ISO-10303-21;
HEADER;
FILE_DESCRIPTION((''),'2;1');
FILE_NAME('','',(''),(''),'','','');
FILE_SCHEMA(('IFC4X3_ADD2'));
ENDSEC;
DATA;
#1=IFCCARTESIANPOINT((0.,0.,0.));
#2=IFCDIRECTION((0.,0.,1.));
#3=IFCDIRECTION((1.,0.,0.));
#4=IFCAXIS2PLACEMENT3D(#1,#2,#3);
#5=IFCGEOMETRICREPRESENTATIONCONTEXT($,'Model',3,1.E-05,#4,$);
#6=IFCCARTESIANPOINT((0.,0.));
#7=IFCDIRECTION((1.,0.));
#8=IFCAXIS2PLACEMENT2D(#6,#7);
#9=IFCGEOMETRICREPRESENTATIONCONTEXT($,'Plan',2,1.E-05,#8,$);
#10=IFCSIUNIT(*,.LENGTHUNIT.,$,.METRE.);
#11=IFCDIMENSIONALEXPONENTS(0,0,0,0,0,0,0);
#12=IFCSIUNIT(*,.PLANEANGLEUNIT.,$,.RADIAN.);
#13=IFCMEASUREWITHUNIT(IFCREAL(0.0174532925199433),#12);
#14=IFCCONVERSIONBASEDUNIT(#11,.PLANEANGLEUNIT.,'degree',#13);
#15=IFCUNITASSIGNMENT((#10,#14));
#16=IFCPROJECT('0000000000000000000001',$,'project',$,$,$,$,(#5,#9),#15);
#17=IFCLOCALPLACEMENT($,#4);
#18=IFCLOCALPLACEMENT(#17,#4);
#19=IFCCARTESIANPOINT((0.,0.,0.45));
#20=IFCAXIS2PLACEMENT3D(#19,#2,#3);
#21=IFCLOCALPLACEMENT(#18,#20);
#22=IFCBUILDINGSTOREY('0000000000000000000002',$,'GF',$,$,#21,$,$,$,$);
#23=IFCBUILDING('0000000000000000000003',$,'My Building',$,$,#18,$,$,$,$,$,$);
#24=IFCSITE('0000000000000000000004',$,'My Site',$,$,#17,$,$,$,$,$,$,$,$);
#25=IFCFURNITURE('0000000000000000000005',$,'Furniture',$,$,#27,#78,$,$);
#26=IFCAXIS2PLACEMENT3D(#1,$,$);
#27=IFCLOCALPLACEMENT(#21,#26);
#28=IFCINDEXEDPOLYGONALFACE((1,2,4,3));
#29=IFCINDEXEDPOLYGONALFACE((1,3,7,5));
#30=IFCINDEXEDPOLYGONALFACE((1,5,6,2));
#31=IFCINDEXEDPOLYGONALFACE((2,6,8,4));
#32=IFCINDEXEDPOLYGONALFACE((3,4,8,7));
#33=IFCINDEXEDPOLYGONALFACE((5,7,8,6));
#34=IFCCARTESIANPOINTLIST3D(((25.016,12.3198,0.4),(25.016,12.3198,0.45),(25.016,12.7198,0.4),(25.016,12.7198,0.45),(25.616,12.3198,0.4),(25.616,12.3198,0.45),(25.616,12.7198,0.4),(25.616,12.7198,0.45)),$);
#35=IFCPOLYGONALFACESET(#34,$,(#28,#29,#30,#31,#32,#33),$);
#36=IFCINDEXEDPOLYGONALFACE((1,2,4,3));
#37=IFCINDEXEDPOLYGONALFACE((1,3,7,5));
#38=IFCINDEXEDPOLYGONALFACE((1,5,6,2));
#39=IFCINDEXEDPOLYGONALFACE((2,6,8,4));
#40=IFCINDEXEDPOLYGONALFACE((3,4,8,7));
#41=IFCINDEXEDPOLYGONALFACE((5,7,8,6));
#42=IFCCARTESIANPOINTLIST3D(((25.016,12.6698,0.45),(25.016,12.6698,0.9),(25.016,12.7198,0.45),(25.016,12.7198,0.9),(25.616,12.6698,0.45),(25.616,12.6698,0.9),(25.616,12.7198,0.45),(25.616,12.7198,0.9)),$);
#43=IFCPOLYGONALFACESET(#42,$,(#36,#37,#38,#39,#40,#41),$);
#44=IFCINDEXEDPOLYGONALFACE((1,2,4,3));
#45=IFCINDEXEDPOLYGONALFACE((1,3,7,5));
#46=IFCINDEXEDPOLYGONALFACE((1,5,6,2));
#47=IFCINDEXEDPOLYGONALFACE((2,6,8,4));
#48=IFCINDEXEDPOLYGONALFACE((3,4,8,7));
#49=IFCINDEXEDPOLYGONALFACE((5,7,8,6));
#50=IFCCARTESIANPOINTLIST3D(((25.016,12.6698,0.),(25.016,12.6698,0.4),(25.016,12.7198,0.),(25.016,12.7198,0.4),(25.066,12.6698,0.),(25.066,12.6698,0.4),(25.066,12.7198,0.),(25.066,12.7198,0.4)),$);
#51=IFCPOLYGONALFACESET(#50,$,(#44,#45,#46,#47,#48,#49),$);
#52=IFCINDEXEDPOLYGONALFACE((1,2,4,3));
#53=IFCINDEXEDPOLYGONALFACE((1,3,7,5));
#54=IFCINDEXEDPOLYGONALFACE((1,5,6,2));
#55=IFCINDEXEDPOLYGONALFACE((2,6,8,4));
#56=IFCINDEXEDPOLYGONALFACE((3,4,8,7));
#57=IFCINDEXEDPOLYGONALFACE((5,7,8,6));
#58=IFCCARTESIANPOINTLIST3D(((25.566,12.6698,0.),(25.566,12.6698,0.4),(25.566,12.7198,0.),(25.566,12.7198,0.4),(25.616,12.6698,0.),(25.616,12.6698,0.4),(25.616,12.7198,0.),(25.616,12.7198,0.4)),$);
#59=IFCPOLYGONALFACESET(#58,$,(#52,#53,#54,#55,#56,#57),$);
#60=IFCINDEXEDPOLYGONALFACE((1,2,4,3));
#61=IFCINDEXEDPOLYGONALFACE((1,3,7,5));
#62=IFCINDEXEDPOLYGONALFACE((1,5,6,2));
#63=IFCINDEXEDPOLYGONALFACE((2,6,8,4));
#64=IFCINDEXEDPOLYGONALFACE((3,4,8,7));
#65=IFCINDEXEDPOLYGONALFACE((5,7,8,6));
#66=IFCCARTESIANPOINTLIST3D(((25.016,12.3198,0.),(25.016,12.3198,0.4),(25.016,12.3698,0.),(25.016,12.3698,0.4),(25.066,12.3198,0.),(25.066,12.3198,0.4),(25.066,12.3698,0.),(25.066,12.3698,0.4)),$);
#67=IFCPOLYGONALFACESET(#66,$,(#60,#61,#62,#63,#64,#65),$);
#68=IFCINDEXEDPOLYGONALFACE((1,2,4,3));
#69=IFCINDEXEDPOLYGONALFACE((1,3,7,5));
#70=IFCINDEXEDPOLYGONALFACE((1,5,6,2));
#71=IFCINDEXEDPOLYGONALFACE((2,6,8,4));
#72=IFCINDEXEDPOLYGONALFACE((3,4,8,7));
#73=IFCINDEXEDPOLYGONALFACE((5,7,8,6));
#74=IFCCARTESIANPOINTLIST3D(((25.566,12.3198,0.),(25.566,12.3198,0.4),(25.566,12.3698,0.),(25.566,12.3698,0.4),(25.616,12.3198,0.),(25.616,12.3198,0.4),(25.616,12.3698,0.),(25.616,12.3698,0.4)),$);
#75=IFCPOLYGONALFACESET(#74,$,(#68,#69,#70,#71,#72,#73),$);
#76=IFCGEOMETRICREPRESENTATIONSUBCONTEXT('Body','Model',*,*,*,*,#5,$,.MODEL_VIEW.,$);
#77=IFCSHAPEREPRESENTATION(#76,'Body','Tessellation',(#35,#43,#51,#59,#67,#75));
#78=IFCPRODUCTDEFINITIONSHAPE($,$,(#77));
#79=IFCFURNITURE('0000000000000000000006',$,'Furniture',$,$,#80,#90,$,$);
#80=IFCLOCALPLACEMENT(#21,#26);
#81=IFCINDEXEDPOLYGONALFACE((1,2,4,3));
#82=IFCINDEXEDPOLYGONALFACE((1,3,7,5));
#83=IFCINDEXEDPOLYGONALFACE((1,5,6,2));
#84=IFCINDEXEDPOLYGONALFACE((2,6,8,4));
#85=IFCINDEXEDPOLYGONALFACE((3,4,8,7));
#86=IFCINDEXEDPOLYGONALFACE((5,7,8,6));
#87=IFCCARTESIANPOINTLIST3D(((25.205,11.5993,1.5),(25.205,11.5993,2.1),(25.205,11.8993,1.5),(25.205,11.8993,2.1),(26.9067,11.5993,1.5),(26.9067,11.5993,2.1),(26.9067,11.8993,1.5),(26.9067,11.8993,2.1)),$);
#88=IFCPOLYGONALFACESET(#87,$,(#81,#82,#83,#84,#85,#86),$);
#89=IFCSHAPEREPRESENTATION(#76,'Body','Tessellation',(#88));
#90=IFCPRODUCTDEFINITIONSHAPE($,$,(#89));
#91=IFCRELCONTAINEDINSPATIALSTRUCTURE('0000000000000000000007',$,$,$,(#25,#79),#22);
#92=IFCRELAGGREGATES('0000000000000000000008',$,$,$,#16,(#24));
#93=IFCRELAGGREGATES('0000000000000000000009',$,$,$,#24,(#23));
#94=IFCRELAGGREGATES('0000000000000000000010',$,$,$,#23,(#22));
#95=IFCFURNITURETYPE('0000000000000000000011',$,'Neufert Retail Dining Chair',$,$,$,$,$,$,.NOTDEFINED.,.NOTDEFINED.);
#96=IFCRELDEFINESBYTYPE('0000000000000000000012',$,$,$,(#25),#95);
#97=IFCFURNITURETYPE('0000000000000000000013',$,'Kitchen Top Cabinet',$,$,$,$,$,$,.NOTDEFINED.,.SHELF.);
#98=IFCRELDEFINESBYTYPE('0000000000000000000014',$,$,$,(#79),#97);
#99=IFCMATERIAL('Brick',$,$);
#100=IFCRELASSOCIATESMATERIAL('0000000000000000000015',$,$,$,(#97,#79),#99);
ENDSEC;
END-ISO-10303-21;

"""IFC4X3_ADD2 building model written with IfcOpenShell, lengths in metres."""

from ifc_helpers import new_model, entity, si_unit, converted_unit, frame, origin_with_axes, origin_2d_with_axis, place, context, subcontext, project, spatial, line, indexed_curve, rectangle, outline, extrude, shape, source, transform, mapped, material, material_profile, profile_set, profile_usage, type_object, type_shapes, element, save


model = new_model("IFC4X3_ADD2")

# Units and contexts
model_context = context("Model", 3, precision=1e-05, world=origin_with_axes())
plan_context = context("Plan", 2, precision=1e-05, world=origin_2d_with_axis())
body_context_1 = subcontext(model_context, "Body", "Model", "MODEL_VIEW")
body_context_2 = subcontext(plan_context, "Body", "Plan", "PLAN_VIEW")
ifc_project = project(units=[si_unit("LENGTHUNIT", "METRE"), converted_unit("PLANEANGLEUNIT", "degree", entity("IfcReal", 0.0174532925199433), si_unit("PLANEANGLEUNIT", "RADIAN"), dimensions=[0, 0, 0, 0, 0, 0, 0])], contexts=[model_context, plan_context])

# Site, building, storey
site_placement = place(None, origin_with_axes())
site = spatial("IfcSite", under=ifc_project, at=site_placement, Name="My Site")
building_placement = place(site_placement, origin_with_axes())
building = spatial("IfcBuilding", under=site, at=building_placement, Name="My Building")
storey_placement = place(building_placement, frame((0.0, 0.0, 0.45), z_axis=(0.0, 0.0, 1.0), x_axis=(1.0, 0.0, 0.0)))
storey = spatial("IfcBuildingStorey", under=building, at=storey_placement, Name="GF")

# Furniture
furniture_type_1 = type_object("IfcFurnitureType", Name="Neufert Retail Dining Chair", AssemblyPlace="NOTDEFINED", PredefinedType="NOTDEFINED")
shared_shape_1 = source(origin_with_axes(), body_context_1, "Body", "SweptSolid", [
    extrude(outline(indexed_curve([(-0.3, 0.0), (0.3, 0.0), (0.3, -0.4), (-0.3, -0.4)], segments=[line(1, 2, 3, 4, 1)])), frame((0.0, 0.0, 0.45), z_axis=(0.0, 0.0, 1.0), x_axis=(1.0, 0.0, 0.0)), (0.0, 0.0, -1.0), 0.05),
    extrude(outline(indexed_curve([(-0.3, 0.0), (0.3, 0.0), (0.3, -0.05), (-0.3, -0.05)], segments=[line(1, 2, 3, 4, 1)])), frame((0.0, 0.0, 0.9), z_axis=(0.0, 0.0, 1.0), x_axis=(1.0, 0.0, 0.0)), (0.0, 0.0, -1.0), 0.45),
    extrude(outline(indexed_curve([(-0.3, 0.0), (-0.25, 0.0), (-0.25, -0.05), (-0.3, -0.05)], segments=[line(1, 2, 3, 4, 1)])), origin_with_axes(), (0.0, 0.0, 1.0), 0.4),
    extrude(outline(indexed_curve([(0.3, 0.0), (0.25, 0.0), (0.25, -0.05), (0.3, -0.05)], segments=[line(1, 2, 3, 4, 1)])), origin_with_axes(), (0.0, 0.0, 1.0), 0.4),
    extrude(outline(indexed_curve([(-0.3, -0.4), (-0.25, -0.4), (-0.25, -0.35), (-0.3, -0.35)], segments=[line(1, 2, 3, 4, 1)])), origin_with_axes(), (0.0, 0.0, 1.0), 0.4),
    extrude(outline(indexed_curve([(0.3, -0.4), (0.25, -0.4), (0.25, -0.35), (0.3, -0.35)], segments=[line(1, 2, 3, 4, 1)])), origin_with_axes(), (0.0, 0.0, 1.0), 0.4),
])
shared_shape_2 = source(origin_with_axes(), body_context_2, "Body", "Curve2D", [
    entity("IfcIndexedPolyCurve", entity("IfcCartesianPointList2D", [[-0.3, -0.4], [0.3, -0.4]])),
    entity("IfcIndexedPolyCurve", entity("IfcCartesianPointList2D", [[-0.3, -0.4], [-0.3, -0.3], [-0.2121, -0.0879], [0.0, 0.0], [0.2121, -0.0879], [0.3, -0.3], [0.3, -0.4]]), [entity("IfcLineIndex", [1, 2]), entity("IfcArcIndex", [2, 3, 4]), entity("IfcArcIndex", [4, 5, 6]), entity("IfcLineIndex", [6, 7])]),
    entity("IfcIndexedPolyCurve", entity("IfcCartesianPointList2D", [[-0.26, -0.4], [-0.26, -0.3], [-0.1838, -0.1162], [0.0, -0.04], [0.1838, -0.1162], [0.26, -0.3], [0.26, -0.4]]), [entity("IfcLineIndex", [1, 2]), entity("IfcArcIndex", [2, 3, 4]), entity("IfcArcIndex", [4, 5, 6]), entity("IfcLineIndex", [6, 7])]),
])
type_shapes(furniture_type_1, [shared_shape_1, shared_shape_2])
furniture_1_placement = place(storey_placement, frame((25.316, 12.7198, 0.0), z_axis=(0.0, 0.0, 1.0), x_axis=(1.0, -0.000001, 0.0)))
element("IfcFurniture", 1, at=furniture_1_placement, inside=storey, type_object=furniture_type_1, Name="Furniture", shapes=[
    shape(body_context_1, "Body", "MappedRepresentation", [mapped(shared_shape_1, transform((0.0, 0.0, 0.0), x_axis=(1.0, 0.0, 0.0), y_axis=(0.0, 1.0, 0.0), z_axis=(0.0, 0.0, 1.0), scale=1.0))]),
    shape(body_context_2, "Body", "MappedRepresentation", [mapped(shared_shape_2, transform((0.0, 0.0, 0.0), x_axis=(1.0, 0.0, 0.0), y_axis=(0.0, 1.0, 0.0), z_axis=(0.0, 0.0, 1.0), scale=1.0))]),
])
ifc_material_1 = material(Name="Brick")
ifc_material_profile_1 = material_profile(ifc_material_1, rectangle(XDim=0.3, YDim=0.6))
ifc_profile_set_1 = profile_set([ifc_material_profile_1])
ifc_profile_usage_1 = profile_usage(ifc_profile_set_1, cardinal=5)
furniture_type_2 = type_object("IfcFurnitureType", Name="Kitchen Top Cabinet", AssemblyPlace="NOTDEFINED", PredefinedType="SHELF", material=ifc_profile_set_1)
furniture_2_placement = place(storey_placement, frame((25.205, 11.7493, 1.8), z_axis=(1.0, 0.0, 0.0), x_axis=(0.0, 1.0, 0.0)))
element("IfcFurniture", 2, at=furniture_2_placement, inside=storey, type_object=furniture_type_2, material=ifc_profile_usage_1, Name="Furniture", context=body_context_1, shape_type="SweptSolid", body=[
    extrude(rectangle(XDim=0.3, YDim=0.6), origin_with_axes(), (0.0, 0.0, 1.0), 1.7017),
])

save(model, "model.ifc")
